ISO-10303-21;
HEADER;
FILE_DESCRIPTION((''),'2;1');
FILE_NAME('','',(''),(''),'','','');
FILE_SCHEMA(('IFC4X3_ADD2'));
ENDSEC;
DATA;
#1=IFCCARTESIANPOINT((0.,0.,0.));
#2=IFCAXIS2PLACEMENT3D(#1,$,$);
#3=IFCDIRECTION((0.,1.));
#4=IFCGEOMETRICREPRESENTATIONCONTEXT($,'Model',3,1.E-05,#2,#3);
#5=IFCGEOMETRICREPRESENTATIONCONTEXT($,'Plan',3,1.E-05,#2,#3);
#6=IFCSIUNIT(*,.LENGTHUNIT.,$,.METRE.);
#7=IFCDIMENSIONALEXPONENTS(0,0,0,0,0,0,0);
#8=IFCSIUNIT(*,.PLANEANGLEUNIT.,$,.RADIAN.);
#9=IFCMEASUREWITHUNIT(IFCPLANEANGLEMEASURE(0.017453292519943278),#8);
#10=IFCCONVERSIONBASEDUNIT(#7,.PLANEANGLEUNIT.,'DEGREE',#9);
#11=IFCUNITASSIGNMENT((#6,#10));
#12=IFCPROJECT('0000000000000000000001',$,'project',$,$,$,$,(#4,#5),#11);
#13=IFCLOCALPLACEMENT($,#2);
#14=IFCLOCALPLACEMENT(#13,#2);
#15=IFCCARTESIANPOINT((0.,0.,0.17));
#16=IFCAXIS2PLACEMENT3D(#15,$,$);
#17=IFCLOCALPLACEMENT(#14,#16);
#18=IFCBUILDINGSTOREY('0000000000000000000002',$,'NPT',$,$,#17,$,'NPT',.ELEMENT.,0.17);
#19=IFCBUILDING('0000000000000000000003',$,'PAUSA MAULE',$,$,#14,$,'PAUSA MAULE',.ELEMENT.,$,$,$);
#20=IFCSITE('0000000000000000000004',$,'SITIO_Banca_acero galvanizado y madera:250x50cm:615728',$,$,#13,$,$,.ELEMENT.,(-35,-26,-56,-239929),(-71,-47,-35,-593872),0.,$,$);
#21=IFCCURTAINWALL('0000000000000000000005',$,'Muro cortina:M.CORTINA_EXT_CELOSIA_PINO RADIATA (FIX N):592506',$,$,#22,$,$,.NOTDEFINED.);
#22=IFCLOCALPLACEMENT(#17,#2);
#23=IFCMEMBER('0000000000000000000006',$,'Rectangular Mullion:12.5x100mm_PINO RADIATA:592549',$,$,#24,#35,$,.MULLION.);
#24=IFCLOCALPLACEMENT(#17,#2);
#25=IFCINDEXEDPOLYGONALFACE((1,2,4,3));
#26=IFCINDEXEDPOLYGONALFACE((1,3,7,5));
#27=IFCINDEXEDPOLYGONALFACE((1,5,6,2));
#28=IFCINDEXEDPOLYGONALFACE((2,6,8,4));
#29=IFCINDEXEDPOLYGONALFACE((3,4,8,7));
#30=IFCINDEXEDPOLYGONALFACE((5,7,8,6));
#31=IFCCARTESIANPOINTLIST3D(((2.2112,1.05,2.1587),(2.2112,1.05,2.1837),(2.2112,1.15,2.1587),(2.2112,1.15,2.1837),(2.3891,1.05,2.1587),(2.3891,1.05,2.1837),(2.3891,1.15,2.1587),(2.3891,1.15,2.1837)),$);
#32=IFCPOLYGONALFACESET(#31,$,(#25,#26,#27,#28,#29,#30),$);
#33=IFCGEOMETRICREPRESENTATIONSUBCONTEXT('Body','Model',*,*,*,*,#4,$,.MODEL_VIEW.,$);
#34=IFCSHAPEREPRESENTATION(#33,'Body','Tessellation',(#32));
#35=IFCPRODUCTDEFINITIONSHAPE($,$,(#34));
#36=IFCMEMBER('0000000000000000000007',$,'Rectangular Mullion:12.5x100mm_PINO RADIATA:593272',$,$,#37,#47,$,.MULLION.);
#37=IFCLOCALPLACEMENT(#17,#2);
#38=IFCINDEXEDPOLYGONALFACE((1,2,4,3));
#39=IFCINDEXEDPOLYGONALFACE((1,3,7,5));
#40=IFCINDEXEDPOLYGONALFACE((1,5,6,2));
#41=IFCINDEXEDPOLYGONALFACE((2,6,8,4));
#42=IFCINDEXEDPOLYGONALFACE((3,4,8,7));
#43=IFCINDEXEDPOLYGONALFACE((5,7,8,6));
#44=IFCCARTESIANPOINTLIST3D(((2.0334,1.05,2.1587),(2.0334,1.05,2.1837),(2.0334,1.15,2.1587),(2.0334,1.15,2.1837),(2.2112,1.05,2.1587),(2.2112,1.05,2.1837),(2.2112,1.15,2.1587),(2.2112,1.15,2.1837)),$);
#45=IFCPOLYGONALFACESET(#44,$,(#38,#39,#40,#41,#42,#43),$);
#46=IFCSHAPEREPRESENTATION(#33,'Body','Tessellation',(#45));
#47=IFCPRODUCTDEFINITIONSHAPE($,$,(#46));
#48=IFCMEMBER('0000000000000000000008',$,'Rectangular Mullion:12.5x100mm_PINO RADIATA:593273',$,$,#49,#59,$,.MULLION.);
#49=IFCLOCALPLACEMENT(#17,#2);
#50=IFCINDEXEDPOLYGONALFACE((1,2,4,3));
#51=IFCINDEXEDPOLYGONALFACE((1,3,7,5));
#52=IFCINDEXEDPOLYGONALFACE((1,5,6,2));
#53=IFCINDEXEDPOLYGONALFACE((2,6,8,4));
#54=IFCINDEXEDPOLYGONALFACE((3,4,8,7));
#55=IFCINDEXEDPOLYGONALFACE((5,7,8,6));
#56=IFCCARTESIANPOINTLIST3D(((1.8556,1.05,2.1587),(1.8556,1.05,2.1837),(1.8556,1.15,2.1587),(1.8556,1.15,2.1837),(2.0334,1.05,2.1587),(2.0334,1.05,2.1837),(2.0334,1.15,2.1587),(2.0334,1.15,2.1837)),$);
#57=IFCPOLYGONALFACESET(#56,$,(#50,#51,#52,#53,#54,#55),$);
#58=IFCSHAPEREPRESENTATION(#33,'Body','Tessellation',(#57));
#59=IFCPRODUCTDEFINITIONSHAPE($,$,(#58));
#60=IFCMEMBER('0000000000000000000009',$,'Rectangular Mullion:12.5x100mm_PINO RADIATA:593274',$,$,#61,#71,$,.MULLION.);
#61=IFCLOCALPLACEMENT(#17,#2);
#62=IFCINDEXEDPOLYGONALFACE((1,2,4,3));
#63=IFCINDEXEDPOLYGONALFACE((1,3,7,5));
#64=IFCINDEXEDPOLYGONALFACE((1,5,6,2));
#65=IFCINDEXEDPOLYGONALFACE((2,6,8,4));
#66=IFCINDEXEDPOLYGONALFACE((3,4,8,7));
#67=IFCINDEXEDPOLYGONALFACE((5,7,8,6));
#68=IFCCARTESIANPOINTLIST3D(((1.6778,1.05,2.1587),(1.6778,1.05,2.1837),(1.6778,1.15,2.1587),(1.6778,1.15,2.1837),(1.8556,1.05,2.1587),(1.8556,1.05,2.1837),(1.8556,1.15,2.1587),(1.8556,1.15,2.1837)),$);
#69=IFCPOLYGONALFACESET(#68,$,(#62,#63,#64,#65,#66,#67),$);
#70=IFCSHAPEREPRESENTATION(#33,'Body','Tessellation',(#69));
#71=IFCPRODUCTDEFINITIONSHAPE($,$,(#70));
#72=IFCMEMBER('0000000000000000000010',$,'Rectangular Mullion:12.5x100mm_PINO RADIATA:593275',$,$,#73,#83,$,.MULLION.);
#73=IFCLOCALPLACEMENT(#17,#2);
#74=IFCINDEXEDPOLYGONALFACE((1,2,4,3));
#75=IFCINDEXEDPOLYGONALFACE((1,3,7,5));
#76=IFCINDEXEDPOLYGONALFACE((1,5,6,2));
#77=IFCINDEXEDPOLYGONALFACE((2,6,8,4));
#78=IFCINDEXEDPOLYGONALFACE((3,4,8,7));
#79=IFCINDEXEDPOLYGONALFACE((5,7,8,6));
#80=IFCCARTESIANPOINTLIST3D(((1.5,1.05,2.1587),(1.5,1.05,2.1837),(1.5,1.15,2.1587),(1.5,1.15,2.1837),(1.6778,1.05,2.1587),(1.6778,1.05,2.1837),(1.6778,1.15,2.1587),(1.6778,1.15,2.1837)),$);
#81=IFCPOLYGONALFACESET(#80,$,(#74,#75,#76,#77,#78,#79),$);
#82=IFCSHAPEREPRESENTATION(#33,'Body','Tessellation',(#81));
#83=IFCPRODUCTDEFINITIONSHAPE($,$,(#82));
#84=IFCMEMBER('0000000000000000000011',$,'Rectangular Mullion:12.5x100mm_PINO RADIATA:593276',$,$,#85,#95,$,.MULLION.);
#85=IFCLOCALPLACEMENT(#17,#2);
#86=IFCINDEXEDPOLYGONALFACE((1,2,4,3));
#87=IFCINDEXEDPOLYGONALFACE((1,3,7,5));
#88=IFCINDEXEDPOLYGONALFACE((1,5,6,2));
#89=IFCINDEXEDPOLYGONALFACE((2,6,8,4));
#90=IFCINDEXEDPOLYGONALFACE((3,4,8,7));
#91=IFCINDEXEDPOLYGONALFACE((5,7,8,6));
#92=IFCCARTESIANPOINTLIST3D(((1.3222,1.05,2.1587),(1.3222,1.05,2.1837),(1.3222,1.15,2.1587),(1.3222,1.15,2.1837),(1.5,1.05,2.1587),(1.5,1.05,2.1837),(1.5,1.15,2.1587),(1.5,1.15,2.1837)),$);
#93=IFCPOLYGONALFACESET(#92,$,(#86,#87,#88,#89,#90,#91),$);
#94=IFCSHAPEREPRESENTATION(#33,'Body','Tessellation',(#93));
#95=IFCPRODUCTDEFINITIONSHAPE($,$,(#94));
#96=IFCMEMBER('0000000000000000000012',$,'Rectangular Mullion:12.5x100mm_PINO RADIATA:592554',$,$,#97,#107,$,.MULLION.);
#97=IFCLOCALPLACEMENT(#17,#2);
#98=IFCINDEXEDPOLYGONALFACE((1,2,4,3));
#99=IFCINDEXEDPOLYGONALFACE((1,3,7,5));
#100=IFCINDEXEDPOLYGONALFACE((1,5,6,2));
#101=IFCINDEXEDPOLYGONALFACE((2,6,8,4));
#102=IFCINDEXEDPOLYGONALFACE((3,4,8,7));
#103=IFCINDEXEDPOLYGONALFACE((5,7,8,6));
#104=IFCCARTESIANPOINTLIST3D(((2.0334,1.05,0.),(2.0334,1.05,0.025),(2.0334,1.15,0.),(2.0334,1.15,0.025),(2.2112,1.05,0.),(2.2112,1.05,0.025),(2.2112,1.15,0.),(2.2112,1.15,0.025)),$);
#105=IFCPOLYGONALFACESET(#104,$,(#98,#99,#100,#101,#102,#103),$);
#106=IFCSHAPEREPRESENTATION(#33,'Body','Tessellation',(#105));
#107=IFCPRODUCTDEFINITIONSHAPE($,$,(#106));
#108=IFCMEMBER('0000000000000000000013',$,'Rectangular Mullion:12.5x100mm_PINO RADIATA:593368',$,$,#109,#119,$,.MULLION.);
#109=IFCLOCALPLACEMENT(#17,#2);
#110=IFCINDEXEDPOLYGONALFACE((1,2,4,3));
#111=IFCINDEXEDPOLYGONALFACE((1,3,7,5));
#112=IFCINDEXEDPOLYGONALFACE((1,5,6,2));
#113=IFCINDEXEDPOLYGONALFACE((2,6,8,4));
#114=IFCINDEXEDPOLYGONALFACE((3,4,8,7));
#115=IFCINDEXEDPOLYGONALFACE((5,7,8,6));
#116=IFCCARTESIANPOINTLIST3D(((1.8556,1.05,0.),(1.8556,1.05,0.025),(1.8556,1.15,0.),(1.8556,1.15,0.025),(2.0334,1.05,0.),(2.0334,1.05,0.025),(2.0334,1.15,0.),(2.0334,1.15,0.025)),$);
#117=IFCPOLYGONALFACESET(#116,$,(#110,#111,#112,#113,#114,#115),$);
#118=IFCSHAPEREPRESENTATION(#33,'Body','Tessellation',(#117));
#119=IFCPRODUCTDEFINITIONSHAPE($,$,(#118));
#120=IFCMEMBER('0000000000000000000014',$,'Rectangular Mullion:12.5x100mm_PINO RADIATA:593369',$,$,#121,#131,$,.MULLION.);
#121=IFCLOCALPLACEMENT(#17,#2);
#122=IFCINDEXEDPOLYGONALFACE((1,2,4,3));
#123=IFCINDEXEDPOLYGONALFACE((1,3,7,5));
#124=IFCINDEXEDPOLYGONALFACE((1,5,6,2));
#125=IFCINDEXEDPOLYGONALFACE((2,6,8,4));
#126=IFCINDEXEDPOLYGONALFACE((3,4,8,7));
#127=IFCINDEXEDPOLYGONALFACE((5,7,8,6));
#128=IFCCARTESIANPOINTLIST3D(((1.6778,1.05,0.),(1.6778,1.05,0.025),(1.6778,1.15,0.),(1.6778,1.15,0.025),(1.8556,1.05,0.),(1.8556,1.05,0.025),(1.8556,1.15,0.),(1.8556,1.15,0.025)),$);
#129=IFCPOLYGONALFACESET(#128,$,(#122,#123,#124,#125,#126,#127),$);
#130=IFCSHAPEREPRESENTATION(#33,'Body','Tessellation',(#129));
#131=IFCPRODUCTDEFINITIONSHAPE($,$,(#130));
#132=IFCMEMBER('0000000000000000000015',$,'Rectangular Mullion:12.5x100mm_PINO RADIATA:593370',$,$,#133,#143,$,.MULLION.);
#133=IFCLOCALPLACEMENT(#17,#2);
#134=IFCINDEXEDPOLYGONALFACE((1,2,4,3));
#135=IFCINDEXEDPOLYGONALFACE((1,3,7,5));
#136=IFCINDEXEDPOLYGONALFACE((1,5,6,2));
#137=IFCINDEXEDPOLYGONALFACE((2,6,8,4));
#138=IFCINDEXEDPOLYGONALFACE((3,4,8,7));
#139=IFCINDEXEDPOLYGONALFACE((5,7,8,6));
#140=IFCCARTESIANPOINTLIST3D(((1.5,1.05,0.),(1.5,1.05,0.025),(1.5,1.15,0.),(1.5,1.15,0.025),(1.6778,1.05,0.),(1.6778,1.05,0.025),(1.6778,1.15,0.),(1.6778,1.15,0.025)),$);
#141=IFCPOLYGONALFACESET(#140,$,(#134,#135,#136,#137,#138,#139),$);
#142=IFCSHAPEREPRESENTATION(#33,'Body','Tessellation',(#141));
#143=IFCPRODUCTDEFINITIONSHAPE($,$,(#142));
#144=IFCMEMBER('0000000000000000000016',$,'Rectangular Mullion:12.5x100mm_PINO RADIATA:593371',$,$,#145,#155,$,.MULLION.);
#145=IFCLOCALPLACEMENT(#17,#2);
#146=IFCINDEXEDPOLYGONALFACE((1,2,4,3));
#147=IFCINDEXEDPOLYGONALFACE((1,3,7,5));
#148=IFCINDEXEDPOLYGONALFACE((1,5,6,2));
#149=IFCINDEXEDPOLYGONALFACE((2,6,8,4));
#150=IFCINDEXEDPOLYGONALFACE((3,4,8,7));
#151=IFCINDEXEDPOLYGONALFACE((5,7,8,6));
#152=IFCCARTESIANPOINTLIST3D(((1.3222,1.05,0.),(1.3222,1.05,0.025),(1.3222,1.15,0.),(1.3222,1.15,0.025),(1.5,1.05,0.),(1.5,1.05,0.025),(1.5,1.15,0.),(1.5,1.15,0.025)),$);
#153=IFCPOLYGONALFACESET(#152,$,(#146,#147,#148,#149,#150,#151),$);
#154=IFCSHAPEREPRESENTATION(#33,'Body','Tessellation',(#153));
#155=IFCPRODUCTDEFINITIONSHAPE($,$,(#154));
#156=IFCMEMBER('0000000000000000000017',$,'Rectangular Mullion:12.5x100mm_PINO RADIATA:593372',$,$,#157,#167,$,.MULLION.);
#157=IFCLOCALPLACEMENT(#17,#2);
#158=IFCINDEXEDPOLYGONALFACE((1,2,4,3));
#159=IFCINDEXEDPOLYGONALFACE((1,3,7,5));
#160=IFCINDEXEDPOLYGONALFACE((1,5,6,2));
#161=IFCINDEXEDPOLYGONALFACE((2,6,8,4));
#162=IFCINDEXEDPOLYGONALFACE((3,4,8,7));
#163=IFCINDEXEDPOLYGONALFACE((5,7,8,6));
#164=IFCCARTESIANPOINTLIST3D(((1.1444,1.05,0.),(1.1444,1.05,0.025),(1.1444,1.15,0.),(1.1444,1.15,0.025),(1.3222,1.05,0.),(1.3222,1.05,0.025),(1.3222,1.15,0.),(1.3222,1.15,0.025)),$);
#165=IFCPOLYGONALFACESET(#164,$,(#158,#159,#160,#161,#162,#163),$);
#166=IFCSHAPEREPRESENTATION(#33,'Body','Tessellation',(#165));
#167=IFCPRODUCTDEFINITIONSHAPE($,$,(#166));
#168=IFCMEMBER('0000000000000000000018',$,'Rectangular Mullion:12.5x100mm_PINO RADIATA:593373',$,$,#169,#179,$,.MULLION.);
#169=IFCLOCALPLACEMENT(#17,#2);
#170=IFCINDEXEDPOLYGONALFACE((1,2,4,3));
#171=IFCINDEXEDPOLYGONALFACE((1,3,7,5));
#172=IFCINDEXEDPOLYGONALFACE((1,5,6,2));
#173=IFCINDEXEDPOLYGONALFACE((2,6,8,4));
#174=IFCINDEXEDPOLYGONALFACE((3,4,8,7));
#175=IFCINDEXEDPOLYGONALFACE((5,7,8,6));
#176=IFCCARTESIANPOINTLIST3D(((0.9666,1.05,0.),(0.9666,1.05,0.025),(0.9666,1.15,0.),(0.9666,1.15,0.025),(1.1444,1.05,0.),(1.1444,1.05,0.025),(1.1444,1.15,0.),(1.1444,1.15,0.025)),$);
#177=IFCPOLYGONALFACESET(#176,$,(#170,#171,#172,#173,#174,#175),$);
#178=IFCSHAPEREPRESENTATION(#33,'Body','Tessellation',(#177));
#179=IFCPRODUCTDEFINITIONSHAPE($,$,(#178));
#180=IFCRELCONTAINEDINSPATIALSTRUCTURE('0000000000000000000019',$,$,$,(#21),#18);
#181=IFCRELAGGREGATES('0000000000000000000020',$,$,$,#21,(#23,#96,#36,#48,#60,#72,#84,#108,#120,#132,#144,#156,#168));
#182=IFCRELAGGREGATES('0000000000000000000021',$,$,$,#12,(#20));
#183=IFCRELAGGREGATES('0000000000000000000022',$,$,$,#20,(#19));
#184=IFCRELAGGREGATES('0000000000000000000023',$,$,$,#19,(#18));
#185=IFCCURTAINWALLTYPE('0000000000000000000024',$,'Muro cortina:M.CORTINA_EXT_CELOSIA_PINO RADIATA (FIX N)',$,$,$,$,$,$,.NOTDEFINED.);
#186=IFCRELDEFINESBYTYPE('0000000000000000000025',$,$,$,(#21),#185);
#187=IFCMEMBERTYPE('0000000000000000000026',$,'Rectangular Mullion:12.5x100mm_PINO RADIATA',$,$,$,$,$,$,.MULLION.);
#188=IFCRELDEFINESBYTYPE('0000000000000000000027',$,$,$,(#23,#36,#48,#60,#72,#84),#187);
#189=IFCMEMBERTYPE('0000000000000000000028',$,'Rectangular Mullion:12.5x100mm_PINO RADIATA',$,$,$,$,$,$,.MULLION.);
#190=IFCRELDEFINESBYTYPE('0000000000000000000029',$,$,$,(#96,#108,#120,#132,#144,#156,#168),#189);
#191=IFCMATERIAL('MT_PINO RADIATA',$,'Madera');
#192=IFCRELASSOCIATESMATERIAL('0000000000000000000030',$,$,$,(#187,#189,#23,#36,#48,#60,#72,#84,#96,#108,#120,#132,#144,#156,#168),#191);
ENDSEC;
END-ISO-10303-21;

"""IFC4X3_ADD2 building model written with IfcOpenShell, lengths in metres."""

from ifc_helpers import new_model, entity, si_unit, converted_unit, direction, frame, frame_2d, origin, place, context, subcontext, project, spatial, rectangle, extrude, source, transform, mapped, material, material_profile, profile_set, profile_usage, type_object, type_shapes, element, aggregate, save


model = new_model("IFC4X3_ADD2")

# Units and contexts
model_context = context("Model", 3, precision=1e-05, world=origin(), true_north=direction((0.0, 1.0)))
plan_context = context("Plan", 3, precision=1e-05, world=origin(), true_north=direction((0.0, 1.0)))
body_context = subcontext(model_context, "Body", "Model", "MODEL_VIEW")
ifc_project = project(units=[si_unit("LENGTHUNIT", "METRE"), converted_unit("PLANEANGLEUNIT", "DEGREE", entity("IfcPlaneAngleMeasure", 0.017453292519943278), si_unit("PLANEANGLEUNIT", "RADIAN"), dimensions=[0, 0, 0, 0, 0, 0, 0])], contexts=[model_context, plan_context])

# Site, building, storey
site_placement = place(None, origin())
site = spatial("IfcSite", under=ifc_project, at=site_placement, Name="SITIO_Banca_acero galvanizado y madera:250x50cm:615728", CompositionType="ELEMENT", RefLatitude=(-35, -26, -56, -239929), RefLongitude=(-71, -47, -35, -593872), RefElevation=0.0)
building_placement = place(site_placement, origin())
building = spatial("IfcBuilding", under=site, at=building_placement, Name="PAUSA MAULE", LongName="PAUSA MAULE", CompositionType="ELEMENT")
storey_placement = place(building_placement, frame((0.0, 0.0, 0.17)))
storey = spatial("IfcBuildingStorey", under=building, at=storey_placement, Name="NPT", LongName="NPT", CompositionType="ELEMENT", Elevation=0.17)

# Curtain wall, members
curtain_wall_type = type_object("IfcCurtainWallType", Name="Muro cortina:M.CORTINA_EXT_CELOSIA_PINO RADIATA (FIX N)", PredefinedType="NOTDEFINED")
curtain_wall_placement = place(storey_placement, frame((0.0, 0.0, -0.17)))
curtain_wall = element("IfcCurtainWall", 1, at=curtain_wall_placement, inside=storey, type_object=curtain_wall_type, Name="Muro cortina:M.CORTINA_EXT_CELOSIA_PINO RADIATA (FIX N):592506", PredefinedType="NOTDEFINED")
ifc_material = material(Name="MT_PINO RADIATA", Category="Madera")
ifc_material_profile = material_profile(ifc_material, rectangle(XDim=0.025, YDim=0.1, at=frame_2d((0.0, 0.0), x_axis=(1.0, 0.0))), Name="12.5x100mm_PINO RADIATA")
ifc_profile_set = profile_set([ifc_material_profile], Name="12.5x100mm_PINO RADIATA")
ifc_profile_usage = profile_usage(ifc_profile_set)
member_type_1 = type_object("IfcMemberType", Name="Rectangular Mullion:12.5x100mm_PINO RADIATA", PredefinedType="MULLION", material=ifc_profile_set)
shared_shape_1 = source(origin(), body_context, "Body", "SweptSolid", [
    extrude(rectangle(XDim=0.025, YDim=0.1, at=frame_2d((0.0, 0.0), x_axis=(1.0, 0.0))), frame((-0.0125, 0.0, -0.1778), z_axis=(0.0, 0.0, 1.0), x_axis=(-1.0, 0.0, 0.0)), (0.0, 0.0, 1.0), 0.1778),
])
type_shapes(member_type_1, [shared_shape_1])
member_1_placement = place(curtain_wall_placement, frame((2.2112, 1.1, 2.3537), z_axis=(-1.0, 0.0, 0.0), x_axis=(0.0, 0.0, 1.0)))
member_1 = element("IfcMember", 2, at=member_1_placement, type_object=member_type_1, material=ifc_profile_usage, Name="Rectangular Mullion:12.5x100mm_PINO RADIATA:592549", PredefinedType="MULLION", context=body_context, shape_type="MappedRepresentation", body=[
    mapped(shared_shape_1, transform((0.0, 0.0, 0.0), scale=1.0)),
])
member_2_placement = place(curtain_wall_placement, frame((2.0334, 1.1, 2.3537), z_axis=(-1.0, 0.0, 0.0), x_axis=(0.0, 0.0, 1.0)))
member_2 = element("IfcMember", 3, at=member_2_placement, type_object=member_type_1, material=ifc_profile_usage, Name="Rectangular Mullion:12.5x100mm_PINO RADIATA:593272", PredefinedType="MULLION", context=body_context, shape_type="MappedRepresentation", body=[
    mapped(shared_shape_1, transform((0.0, 0.0, 0.0), scale=1.0)),
])
member_3_placement = place(curtain_wall_placement, frame((1.8556, 1.1, 2.3537), z_axis=(-1.0, 0.0, 0.0), x_axis=(0.0, 0.0, 1.0)))
member_3 = element("IfcMember", 4, at=member_3_placement, type_object=member_type_1, material=ifc_profile_usage, Name="Rectangular Mullion:12.5x100mm_PINO RADIATA:593273", PredefinedType="MULLION", context=body_context, shape_type="MappedRepresentation", body=[
    mapped(shared_shape_1, transform((0.0, 0.0, 0.0), scale=1.0)),
])
member_4_placement = place(curtain_wall_placement, frame((1.6778, 1.1, 2.3537), z_axis=(-1.0, 0.0, 0.0), x_axis=(0.0, 0.0, 1.0)))
member_4 = element("IfcMember", 5, at=member_4_placement, type_object=member_type_1, material=ifc_profile_usage, Name="Rectangular Mullion:12.5x100mm_PINO RADIATA:593274", PredefinedType="MULLION", context=body_context, shape_type="MappedRepresentation", body=[
    mapped(shared_shape_1, transform((0.0, 0.0, 0.0), scale=1.0)),
])
member_5_placement = place(curtain_wall_placement, frame((1.5, 1.1, 2.3537), z_axis=(-1.0, 0.0, 0.0), x_axis=(0.0, 0.0, 1.0)))
member_5 = element("IfcMember", 6, at=member_5_placement, type_object=member_type_1, material=ifc_profile_usage, Name="Rectangular Mullion:12.5x100mm_PINO RADIATA:593275", PredefinedType="MULLION", context=body_context, shape_type="MappedRepresentation", body=[
    mapped(shared_shape_1, transform((0.0, 0.0, 0.0), scale=1.0)),
])
member_6_placement = place(curtain_wall_placement, frame((1.3222, 1.1, 2.3537), z_axis=(-1.0, 0.0, 0.0), x_axis=(0.0, 0.0, 1.0)))
member_6 = element("IfcMember", 7, at=member_6_placement, type_object=member_type_1, material=ifc_profile_usage, Name="Rectangular Mullion:12.5x100mm_PINO RADIATA:593276", PredefinedType="MULLION", context=body_context, shape_type="MappedRepresentation", body=[
    mapped(shared_shape_1, transform((0.0, 0.0, 0.0), scale=1.0)),
])
member_type_2 = type_object("IfcMemberType", Name="Rectangular Mullion:12.5x100mm_PINO RADIATA", PredefinedType="MULLION", material=ifc_profile_set)
shared_shape_2 = source(origin(), body_context, "Body", "SweptSolid", [
    extrude(rectangle(XDim=0.025, YDim=0.1, at=frame_2d((0.0, 0.0), x_axis=(1.0, 0.0))), frame((-0.0125, 0.0, -0.1778), z_axis=(0.0, 0.0, 1.0), x_axis=(-1.0, 0.0, 0.0)), (0.0, 0.0, 1.0), 0.1778),
])
type_shapes(member_type_2, [shared_shape_2])
member_7_placement = place(curtain_wall_placement, frame((2.2112, 1.1, 0.17), z_axis=(1.0, 0.0, 0.0), x_axis=(0.0, 0.0, -1.0)))
member_7 = element("IfcMember", 8, at=member_7_placement, type_object=member_type_2, material=ifc_profile_usage, Name="Rectangular Mullion:12.5x100mm_PINO RADIATA:592554", PredefinedType="MULLION", context=body_context, shape_type="MappedRepresentation", body=[
    mapped(shared_shape_2, transform((0.0, 0.0, 0.0), scale=1.0)),
])
member_8_placement = place(curtain_wall_placement, frame((2.0334, 1.1, 0.17), z_axis=(1.0, 0.0, 0.0), x_axis=(0.0, 0.0, -1.0)))
member_8 = element("IfcMember", 9, at=member_8_placement, type_object=member_type_2, material=ifc_profile_usage, Name="Rectangular Mullion:12.5x100mm_PINO RADIATA:593368", PredefinedType="MULLION", context=body_context, shape_type="MappedRepresentation", body=[
    mapped(shared_shape_2, transform((0.0, 0.0, 0.0), scale=1.0)),
])
member_9_placement = place(curtain_wall_placement, frame((1.8556, 1.1, 0.17), z_axis=(1.0, 0.0, 0.0), x_axis=(0.0, 0.0, -1.0)))
member_9 = element("IfcMember", 10, at=member_9_placement, type_object=member_type_2, material=ifc_profile_usage, Name="Rectangular Mullion:12.5x100mm_PINO RADIATA:593369", PredefinedType="MULLION", context=body_context, shape_type="MappedRepresentation", body=[
    mapped(shared_shape_2, transform((0.0, 0.0, 0.0), scale=1.0)),
])
member_10_placement = place(curtain_wall_placement, frame((1.6778, 1.1, 0.17), z_axis=(1.0, 0.0, 0.0), x_axis=(0.0, 0.0, -1.0)))
member_10 = element("IfcMember", 11, at=member_10_placement, type_object=member_type_2, material=ifc_profile_usage, Name="Rectangular Mullion:12.5x100mm_PINO RADIATA:593370", PredefinedType="MULLION", context=body_context, shape_type="MappedRepresentation", body=[
    mapped(shared_shape_2, transform((0.0, 0.0, 0.0), scale=1.0)),
])
member_11_placement = place(curtain_wall_placement, frame((1.5, 1.1, 0.17), z_axis=(1.0, 0.0, 0.0), x_axis=(0.0, 0.0, -1.0)))
member_11 = element("IfcMember", 12, at=member_11_placement, type_object=member_type_2, material=ifc_profile_usage, Name="Rectangular Mullion:12.5x100mm_PINO RADIATA:593371", PredefinedType="MULLION", context=body_context, shape_type="MappedRepresentation", body=[
    mapped(shared_shape_2, transform((0.0, 0.0, 0.0), scale=1.0)),
])
member_12_placement = place(curtain_wall_placement, frame((1.3222, 1.1, 0.17), z_axis=(1.0, 0.0, 0.0), x_axis=(0.0, 0.0, -1.0)))
member_12 = element("IfcMember", 13, at=member_12_placement, type_object=member_type_2, material=ifc_profile_usage, Name="Rectangular Mullion:12.5x100mm_PINO RADIATA:593372", PredefinedType="MULLION", context=body_context, shape_type="MappedRepresentation", body=[
    mapped(shared_shape_2, transform((0.0, 0.0, 0.0), scale=1.0)),
])
member_13_placement = place(curtain_wall_placement, frame((1.1444, 1.1, 0.17), z_axis=(1.0, 0.0, 0.0), x_axis=(0.0, 0.0, -1.0)))
member_13 = element("IfcMember", 14, at=member_13_placement, type_object=member_type_2, material=ifc_profile_usage, Name="Rectangular Mullion:12.5x100mm_PINO RADIATA:593373", PredefinedType="MULLION", context=body_context, shape_type="MappedRepresentation", body=[
    mapped(shared_shape_2, transform((0.0, 0.0, 0.0), scale=1.0)),
])
aggregate(curtain_wall, [member_1, member_7, member_2, member_3, member_4, member_5, member_6, member_8, member_9, member_10, member_11, member_12, member_13])

save(model, "model.ifc")
